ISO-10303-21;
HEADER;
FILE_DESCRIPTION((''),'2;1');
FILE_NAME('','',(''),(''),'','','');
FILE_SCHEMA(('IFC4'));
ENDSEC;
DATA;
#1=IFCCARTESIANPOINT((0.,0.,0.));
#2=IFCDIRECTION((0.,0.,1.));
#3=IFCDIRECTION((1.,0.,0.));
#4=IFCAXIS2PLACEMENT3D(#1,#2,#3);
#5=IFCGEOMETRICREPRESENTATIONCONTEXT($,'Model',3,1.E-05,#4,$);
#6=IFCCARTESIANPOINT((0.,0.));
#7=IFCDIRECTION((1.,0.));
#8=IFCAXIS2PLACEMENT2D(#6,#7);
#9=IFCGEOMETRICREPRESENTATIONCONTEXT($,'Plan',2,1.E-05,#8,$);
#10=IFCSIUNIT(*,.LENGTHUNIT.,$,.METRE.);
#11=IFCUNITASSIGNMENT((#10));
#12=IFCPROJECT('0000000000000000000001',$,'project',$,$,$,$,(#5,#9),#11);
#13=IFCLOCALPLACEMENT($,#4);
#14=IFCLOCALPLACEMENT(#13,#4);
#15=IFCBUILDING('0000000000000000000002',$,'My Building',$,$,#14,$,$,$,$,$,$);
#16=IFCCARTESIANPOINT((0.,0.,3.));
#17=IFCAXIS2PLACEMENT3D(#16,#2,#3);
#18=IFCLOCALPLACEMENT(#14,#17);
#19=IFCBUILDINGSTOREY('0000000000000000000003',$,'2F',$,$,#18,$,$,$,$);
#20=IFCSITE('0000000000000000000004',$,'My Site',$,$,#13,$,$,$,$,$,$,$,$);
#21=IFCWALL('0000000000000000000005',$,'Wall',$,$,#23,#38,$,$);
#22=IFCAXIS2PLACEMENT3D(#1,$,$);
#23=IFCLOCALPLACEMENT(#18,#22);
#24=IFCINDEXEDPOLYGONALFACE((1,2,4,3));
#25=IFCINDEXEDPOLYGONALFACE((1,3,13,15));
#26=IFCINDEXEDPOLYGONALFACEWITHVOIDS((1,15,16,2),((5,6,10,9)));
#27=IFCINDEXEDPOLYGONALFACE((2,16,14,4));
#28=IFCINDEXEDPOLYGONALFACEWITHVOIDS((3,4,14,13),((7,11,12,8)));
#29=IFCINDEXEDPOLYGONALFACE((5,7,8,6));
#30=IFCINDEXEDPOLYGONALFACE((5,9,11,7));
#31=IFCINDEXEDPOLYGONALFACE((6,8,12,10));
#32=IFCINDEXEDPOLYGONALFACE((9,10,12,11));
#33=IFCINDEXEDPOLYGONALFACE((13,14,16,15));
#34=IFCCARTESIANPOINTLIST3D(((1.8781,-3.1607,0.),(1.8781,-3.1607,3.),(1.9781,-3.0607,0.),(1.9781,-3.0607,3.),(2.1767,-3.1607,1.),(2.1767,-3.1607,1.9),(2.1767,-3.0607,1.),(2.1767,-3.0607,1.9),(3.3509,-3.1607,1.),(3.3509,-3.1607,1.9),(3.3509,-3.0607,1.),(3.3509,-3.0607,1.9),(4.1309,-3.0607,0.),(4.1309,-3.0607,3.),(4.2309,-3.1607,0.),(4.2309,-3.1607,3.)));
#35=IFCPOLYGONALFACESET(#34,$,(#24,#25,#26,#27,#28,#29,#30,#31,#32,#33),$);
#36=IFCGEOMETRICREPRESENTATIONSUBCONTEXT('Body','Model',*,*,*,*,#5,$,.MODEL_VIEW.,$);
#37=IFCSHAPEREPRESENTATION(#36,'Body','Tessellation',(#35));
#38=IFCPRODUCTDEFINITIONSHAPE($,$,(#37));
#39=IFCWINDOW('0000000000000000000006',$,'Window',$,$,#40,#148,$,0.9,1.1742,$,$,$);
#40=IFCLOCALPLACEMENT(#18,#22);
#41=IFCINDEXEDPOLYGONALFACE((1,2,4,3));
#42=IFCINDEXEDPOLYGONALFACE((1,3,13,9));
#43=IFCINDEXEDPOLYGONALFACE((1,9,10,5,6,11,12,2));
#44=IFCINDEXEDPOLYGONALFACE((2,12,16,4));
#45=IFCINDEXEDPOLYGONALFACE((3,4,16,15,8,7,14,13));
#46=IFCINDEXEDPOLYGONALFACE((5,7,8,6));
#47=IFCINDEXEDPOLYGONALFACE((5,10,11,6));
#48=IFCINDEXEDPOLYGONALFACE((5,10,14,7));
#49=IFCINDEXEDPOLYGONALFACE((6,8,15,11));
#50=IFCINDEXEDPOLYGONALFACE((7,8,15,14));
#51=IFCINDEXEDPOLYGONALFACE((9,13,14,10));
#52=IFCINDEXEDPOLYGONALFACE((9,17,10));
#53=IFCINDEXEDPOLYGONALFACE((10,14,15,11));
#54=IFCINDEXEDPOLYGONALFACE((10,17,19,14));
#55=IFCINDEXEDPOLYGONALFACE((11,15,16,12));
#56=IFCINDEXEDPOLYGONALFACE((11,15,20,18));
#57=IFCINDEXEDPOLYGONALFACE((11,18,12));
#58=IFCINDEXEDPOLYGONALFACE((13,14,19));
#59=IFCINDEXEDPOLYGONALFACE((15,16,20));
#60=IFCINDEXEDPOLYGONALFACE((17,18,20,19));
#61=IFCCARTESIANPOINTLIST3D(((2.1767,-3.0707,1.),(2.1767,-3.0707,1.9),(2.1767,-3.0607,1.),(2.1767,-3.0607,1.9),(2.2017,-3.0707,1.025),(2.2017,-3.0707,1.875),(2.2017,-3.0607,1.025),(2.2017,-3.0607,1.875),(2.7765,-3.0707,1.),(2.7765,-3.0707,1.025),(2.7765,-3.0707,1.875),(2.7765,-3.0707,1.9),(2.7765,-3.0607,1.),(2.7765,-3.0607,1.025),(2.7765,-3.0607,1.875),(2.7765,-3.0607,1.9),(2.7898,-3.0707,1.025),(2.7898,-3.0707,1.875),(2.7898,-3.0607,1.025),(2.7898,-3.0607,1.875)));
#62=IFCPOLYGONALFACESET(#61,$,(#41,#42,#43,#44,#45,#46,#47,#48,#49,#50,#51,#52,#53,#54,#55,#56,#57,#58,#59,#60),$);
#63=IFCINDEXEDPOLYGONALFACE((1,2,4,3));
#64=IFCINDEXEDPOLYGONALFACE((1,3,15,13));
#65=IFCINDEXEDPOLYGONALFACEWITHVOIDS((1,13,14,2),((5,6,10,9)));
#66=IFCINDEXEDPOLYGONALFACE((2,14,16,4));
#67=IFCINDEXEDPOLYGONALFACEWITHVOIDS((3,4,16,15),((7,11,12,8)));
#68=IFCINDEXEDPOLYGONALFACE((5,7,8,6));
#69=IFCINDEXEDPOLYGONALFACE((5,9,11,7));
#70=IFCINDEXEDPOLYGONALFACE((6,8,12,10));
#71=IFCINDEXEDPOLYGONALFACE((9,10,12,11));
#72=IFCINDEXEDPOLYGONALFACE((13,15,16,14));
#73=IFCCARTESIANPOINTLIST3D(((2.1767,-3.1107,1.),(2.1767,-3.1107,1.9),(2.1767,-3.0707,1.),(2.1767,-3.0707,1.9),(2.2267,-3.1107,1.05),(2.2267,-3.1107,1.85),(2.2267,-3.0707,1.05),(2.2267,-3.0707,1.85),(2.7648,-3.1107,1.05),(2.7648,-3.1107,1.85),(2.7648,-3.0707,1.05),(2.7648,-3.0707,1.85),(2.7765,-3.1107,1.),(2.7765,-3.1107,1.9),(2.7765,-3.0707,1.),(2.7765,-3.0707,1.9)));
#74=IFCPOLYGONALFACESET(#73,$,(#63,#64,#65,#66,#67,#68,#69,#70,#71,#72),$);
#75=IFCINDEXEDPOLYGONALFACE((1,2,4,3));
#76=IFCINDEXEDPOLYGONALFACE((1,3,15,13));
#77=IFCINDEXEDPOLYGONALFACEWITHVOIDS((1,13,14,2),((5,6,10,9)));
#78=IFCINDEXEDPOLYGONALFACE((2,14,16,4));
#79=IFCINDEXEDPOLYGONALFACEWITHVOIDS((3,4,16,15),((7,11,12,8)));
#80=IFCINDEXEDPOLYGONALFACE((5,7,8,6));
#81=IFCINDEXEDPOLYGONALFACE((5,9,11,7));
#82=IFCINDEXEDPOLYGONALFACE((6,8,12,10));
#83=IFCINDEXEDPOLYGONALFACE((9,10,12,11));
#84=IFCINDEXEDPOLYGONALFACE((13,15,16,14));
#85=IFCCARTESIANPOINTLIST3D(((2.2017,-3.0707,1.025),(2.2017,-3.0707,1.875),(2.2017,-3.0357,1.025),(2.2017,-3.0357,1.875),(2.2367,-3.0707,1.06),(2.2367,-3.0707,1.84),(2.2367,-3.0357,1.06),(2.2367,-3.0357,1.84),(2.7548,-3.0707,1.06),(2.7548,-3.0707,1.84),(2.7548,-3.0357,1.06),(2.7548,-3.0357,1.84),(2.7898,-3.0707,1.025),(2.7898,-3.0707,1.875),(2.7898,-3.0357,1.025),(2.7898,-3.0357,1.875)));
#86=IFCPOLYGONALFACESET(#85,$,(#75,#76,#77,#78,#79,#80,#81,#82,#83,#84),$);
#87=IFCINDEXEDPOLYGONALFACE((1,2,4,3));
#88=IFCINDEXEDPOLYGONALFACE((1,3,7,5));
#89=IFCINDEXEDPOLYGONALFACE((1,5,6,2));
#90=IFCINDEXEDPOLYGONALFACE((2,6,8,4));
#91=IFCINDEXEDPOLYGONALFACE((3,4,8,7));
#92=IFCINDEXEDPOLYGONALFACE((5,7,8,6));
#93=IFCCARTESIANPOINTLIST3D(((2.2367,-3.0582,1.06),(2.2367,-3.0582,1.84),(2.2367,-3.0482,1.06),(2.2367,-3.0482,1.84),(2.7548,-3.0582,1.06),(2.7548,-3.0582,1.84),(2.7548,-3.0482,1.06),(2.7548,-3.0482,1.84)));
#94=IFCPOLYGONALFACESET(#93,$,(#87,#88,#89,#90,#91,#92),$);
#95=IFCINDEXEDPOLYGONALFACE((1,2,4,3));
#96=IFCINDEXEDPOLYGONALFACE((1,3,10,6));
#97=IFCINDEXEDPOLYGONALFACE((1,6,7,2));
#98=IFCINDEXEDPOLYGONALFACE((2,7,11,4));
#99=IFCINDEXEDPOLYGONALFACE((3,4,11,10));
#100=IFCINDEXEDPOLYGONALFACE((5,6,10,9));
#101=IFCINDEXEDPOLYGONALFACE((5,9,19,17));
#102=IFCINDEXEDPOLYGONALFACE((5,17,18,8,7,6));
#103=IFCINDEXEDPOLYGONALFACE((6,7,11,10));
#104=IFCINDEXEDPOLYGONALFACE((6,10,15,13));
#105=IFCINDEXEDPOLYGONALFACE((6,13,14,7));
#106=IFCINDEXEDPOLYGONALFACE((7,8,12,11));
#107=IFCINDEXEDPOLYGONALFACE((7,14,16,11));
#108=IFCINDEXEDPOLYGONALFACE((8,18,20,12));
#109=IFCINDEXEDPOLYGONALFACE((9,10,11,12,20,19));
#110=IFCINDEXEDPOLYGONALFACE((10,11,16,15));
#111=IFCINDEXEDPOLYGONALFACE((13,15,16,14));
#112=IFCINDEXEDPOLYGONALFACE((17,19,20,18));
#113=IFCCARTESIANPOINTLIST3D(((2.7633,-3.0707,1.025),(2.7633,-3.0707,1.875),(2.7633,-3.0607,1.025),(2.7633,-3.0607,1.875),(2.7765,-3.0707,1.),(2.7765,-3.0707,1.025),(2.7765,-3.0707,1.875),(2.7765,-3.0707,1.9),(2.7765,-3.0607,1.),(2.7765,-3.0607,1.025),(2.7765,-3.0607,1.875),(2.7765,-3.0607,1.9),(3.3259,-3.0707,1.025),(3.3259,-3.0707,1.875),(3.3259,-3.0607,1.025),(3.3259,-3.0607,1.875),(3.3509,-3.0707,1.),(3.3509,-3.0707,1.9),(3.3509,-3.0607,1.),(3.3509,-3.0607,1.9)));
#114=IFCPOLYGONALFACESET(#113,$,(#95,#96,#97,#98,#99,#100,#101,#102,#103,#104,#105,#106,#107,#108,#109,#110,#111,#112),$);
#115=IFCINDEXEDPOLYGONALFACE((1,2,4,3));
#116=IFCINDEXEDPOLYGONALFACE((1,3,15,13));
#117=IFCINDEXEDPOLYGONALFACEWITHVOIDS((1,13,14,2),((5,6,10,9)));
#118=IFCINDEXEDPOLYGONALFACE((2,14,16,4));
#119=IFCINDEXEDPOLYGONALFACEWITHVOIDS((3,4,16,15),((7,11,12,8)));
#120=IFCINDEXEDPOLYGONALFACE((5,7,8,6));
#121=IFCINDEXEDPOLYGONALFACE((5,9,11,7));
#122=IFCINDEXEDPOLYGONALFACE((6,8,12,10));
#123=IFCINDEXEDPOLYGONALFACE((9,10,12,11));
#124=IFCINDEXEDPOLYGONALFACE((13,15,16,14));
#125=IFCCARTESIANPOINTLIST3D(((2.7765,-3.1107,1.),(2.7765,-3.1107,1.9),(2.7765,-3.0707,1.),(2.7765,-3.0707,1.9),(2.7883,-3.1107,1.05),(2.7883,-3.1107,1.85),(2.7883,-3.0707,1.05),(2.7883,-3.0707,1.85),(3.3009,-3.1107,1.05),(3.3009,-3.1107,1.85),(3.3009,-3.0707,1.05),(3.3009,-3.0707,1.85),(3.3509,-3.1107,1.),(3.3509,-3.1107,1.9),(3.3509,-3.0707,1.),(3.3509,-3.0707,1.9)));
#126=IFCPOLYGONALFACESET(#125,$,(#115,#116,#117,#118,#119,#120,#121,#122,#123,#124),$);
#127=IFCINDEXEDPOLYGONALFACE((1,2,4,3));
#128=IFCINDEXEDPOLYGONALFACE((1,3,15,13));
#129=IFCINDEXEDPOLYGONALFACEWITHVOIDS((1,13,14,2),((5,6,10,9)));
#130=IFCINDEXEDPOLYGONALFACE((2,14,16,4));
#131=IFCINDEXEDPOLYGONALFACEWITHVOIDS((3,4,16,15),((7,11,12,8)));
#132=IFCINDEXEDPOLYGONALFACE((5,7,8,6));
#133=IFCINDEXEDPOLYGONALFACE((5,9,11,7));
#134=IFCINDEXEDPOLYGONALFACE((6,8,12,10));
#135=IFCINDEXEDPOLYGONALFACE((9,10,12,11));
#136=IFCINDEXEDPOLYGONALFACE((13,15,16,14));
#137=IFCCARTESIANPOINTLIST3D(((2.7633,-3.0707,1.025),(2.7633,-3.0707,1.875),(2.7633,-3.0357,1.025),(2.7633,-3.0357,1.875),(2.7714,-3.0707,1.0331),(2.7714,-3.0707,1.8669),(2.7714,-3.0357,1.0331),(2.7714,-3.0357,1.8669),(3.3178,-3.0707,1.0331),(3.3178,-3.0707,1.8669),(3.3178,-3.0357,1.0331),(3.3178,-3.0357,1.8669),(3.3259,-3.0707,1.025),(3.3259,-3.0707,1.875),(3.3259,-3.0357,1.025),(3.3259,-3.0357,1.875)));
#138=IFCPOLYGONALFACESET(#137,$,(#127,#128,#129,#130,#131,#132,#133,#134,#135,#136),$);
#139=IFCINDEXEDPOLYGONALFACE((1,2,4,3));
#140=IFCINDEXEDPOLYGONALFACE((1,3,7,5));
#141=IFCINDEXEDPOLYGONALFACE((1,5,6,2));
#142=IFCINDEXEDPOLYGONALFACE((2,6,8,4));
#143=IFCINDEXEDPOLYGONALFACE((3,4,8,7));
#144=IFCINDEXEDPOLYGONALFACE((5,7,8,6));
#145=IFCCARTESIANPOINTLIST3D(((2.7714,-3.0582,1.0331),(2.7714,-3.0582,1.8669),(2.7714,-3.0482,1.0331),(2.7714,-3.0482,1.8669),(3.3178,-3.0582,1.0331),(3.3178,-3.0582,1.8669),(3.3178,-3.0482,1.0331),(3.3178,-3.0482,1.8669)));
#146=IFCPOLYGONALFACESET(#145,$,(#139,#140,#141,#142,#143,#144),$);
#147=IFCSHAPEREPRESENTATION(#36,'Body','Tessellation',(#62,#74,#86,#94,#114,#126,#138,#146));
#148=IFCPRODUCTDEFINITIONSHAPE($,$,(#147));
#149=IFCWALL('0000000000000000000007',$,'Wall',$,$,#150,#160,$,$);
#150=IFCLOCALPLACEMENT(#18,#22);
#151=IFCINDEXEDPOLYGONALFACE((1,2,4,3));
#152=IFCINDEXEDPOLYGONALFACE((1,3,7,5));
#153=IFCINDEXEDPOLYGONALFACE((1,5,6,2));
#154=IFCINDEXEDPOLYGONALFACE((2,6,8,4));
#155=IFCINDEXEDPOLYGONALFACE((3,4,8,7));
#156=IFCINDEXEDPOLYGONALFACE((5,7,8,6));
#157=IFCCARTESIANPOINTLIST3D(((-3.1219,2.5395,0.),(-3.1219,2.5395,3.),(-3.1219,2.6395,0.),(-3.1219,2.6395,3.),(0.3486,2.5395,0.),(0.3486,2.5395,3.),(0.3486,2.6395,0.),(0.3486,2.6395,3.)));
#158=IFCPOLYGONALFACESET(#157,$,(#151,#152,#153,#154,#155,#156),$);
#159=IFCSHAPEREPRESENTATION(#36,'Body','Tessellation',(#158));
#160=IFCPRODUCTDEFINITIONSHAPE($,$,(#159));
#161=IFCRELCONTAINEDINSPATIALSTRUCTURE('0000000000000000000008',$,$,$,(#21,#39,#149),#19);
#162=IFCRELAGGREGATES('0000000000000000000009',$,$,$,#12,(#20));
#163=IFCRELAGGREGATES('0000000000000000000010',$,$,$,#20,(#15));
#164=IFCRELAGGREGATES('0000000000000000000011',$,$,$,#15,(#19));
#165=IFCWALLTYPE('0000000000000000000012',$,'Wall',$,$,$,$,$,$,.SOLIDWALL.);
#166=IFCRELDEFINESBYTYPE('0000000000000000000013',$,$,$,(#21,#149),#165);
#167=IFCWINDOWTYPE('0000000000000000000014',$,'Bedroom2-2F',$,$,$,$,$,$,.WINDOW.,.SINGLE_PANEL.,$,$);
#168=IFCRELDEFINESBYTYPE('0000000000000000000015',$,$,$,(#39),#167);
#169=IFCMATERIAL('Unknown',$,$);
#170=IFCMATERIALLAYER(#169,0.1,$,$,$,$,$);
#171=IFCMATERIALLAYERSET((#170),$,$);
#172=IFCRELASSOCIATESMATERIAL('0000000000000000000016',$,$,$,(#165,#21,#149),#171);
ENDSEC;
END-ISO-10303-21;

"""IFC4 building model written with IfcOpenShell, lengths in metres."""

from ifc_helpers import new_model, entity, si_unit, frame, origin_with_axes, origin_2d_with_axis, place, context, subcontext, project, spatial, line, indexed_curve, outline, extrude, shape, source, transform, mapped, material, layer, layer_set, layer_usage, type_object, type_shapes, element, fill, save


model = new_model("IFC4")

# Units and contexts
model_context = context("Model", 3, precision=1e-05, world=origin_with_axes())
plan_context = context("Plan", 2, precision=1e-05, world=origin_2d_with_axis())
body_context_1 = subcontext(model_context, "Body", "Model", "MODEL_VIEW")
body_context_2 = subcontext(plan_context, "Body", "Plan", "PLAN_VIEW")
ifc_project = project(units=[si_unit("LENGTHUNIT", "METRE")], contexts=[model_context, plan_context])

# Site, building, storey
site_placement = place(None, origin_with_axes())
site = spatial("IfcSite", under=ifc_project, at=site_placement, Name="My Site")
building_placement = place(site_placement, origin_with_axes())
building = spatial("IfcBuilding", under=site, at=building_placement, Name="My Building")
storey_placement = place(building_placement, frame((0.0, 0.0, 3.0), z_axis=(0.0, 0.0, 1.0), x_axis=(1.0, 0.0, 0.0)))
storey = spatial("IfcBuildingStorey", under=building, at=storey_placement, Name="2F")

# Shared definitions
ifc_material = material(Name="Unknown")

# Shared definitions
ifc_layer_1 = layer(ifc_material, 0.1)
ifc_layer_set_1 = layer_set([ifc_layer_1])
wall_type = type_object("IfcWallType", Name="Wall", PredefinedType="SOLIDWALL", material=ifc_layer_set_1)

# Wall, opening, window
ifc_layer_usage_1 = layer_usage(ifc_layer_set_1, "AXIS2", "POSITIVE", 0.0)
wall_1_placement = place(storey_placement, frame((1.8781, -3.1607, 0.0), z_axis=(0.0, 0.0, 1.0), x_axis=(1.0, 0.0, 0.0)))
wall_1 = element("IfcWall", 1, at=wall_1_placement, inside=storey, type_object=wall_type, material=ifc_layer_usage_1, Name="Wall", context=body_context_1, shape_type="SweptSolid", body=[
    extrude(outline(indexed_curve([(0.0, 0.0), (0.1, 0.1), (2.2528, 0.1), (2.3528, 0.0)], segments=[line(1, 2, 3, 4, 1)])), origin_with_axes(), (0.0, 0.0, 1.0), 3.0),
])
shared_shape_1 = source(origin_with_axes(), body_context_1, "Body", "SweptSolid", [
    extrude(outline(indexed_curve([(0.0, 0.0), (1.1742, 0.0), (1.1742, 0.9), (0.0, 0.9)], segments=[line(1, 2, 3, 4, 1)])), frame((0.0, -0.6, 0.0), z_axis=(0.0, -1.0, 0.0), x_axis=(1.0, 0.0, 0.0)), (0.0, 0.0, -1.0), 1.2),
])
opening_1_placement = place(wall_1_placement, frame((0.2985, 0.0, 1.0), z_axis=(0.0, 0.0, 1.0), x_axis=(1.0, 0.0, 0.0)))
opening_1 = element("IfcOpeningElement", 2, at=opening_1_placement, cuts=wall_1, PredefinedType="OPENING", context=body_context_1, shape_type="MappedRepresentation", body=[
    mapped(shared_shape_1, transform((0.0, 0.0, 0.0), x_axis=(1.0, 0.0, 0.0), y_axis=(0.0, 1.0, 0.0), z_axis=(0.0, 0.0, 1.0), scale=1.0)),
])
window_type_1 = type_object("IfcWindowType", Name="Bedroom2-2F", PartitioningType="SINGLE_PANEL", PredefinedType="WINDOW")
shared_shape_2 = source(origin_with_axes(), body_context_1, "Body", "SweptSolid", [
    extrude(outline(indexed_curve([(0.0, 0.0), (0.5999, 0.0), (0.5999, 0.9), (0.0, 0.9)], segments=[line(1, 2, 3, 4, 1)]), holes=[indexed_curve([(0.025, 0.025), (0.6131, 0.025), (0.6131, 0.875), (0.025, 0.875)], segments=[line(1, 2, 3, 4, 1)])]), frame((0.0, 0.09, 0.0), z_axis=(0.0, -1.0, 0.0), x_axis=(1.0, 0.0, 0.0)), (0.0, 0.0, -1.0), 0.01),
    extrude(outline(indexed_curve([(0.0, 0.0), (0.5999, 0.0), (0.5999, 0.9), (0.0, 0.9)], segments=[line(1, 2, 3, 4, 1)]), holes=[indexed_curve([(0.05, 0.05), (0.5881, 0.05), (0.5881, 0.85), (0.05, 0.85)], segments=[line(1, 2, 3, 4, 1)])]), frame((0.0, 0.05, 0.0), z_axis=(0.0, -1.0, 0.0), x_axis=(1.0, 0.0, 0.0)), (0.0, 0.0, -1.0), 0.04),
    extrude(outline(indexed_curve([(0.0, 0.0), (0.5881, 0.0), (0.5881, 0.85), (0.0, 0.85)], segments=[line(1, 2, 3, 4, 1)]), holes=[indexed_curve([(0.035, 0.035), (0.5531, 0.035), (0.5531, 0.815), (0.035, 0.815)], segments=[line(1, 2, 3, 4, 1)])]), frame((0.025, 0.09, 0.025), z_axis=(0.0, -1.0, 0.0), x_axis=(1.0, 0.0, 0.0)), (0.0, 0.0, -1.0), 0.035),
    extrude(outline(indexed_curve([(0.035, 0.035), (0.5531, 0.035), (0.5531, 0.815), (0.035, 0.815)], segments=[line(1, 2, 3, 4, 1)])), frame((0.025, 0.1025, 0.025), z_axis=(0.0, -1.0, 0.0), x_axis=(1.0, 0.0, 0.0)), (0.0, 0.0, -1.0), 0.01),
    extrude(outline(indexed_curve([(0.0, 0.0), (0.5744, 0.0), (0.5744, 0.9), (0.0, 0.9)], segments=[line(1, 2, 3, 4, 1)]), holes=[indexed_curve([(-0.0132, 0.025), (0.5494, 0.025), (0.5494, 0.875), (-0.0132, 0.875)], segments=[line(1, 2, 3, 4, 1)])]), frame((0.5999, 0.09, 0.0), z_axis=(0.0, -1.0, 0.0), x_axis=(1.0, 0.0, 0.0)), (0.0, 0.0, -1.0), 0.01),
    extrude(outline(indexed_curve([(0.0, 0.0), (0.5744, 0.0), (0.5744, 0.9), (0.0, 0.9)], segments=[line(1, 2, 3, 4, 1)]), holes=[indexed_curve([(0.0118, 0.05), (0.5244, 0.05), (0.5244, 0.85), (0.0118, 0.85)], segments=[line(1, 2, 3, 4, 1)])]), frame((0.5999, 0.05, 0.0), z_axis=(0.0, -1.0, 0.0), x_axis=(1.0, 0.0, 0.0)), (0.0, 0.0, -1.0), 0.04),
    extrude(outline(indexed_curve([(0.0, 0.0), (0.5626, 0.0), (0.5626, 0.85), (0.0, 0.85)], segments=[line(1, 2, 3, 4, 1)]), holes=[indexed_curve([(0.0081, 0.0081), (0.5545, 0.0081), (0.5545, 0.8419), (0.0081, 0.8419)], segments=[line(1, 2, 3, 4, 1)])]), frame((0.5866, 0.09, 0.025), z_axis=(0.0, -1.0, 0.0), x_axis=(1.0, 0.0, 0.0)), (0.0, 0.0, -1.0), 0.035),
    extrude(outline(indexed_curve([(0.0081, 0.0081), (0.5545, 0.0081), (0.5545, 0.8419), (0.0081, 0.8419)], segments=[line(1, 2, 3, 4, 1)])), frame((0.5866, 0.1025, 0.025), z_axis=(0.0, -1.0, 0.0), x_axis=(1.0, 0.0, 0.0)), (0.0, 0.0, -1.0), 0.01),
])
shared_shape_3 = source(origin_with_axes(), body_context_2, "Body", "Curve2D", [
    entity("IfcIndexedPolyCurve", entity("IfcCartesianPointList2D", [[0.05, 0.05], [0.5881, 0.05]])),
    entity("IfcIndexedPolyCurve", entity("IfcCartesianPointList2D", [[0.0, 0.1], [0.025, 0.1], [0.025, 0.09], [0.05, 0.09], [0.05, 0.05], [0.0, 0.05]]), [entity("IfcLineIndex", [1, 2, 3, 4, 5, 6, 1])]),
    entity("IfcIndexedPolyCurve", entity("IfcCartesianPointList2D", [[0.5999, 0.1], [0.6131, 0.1], [0.6131, 0.09], [0.5881, 0.09], [0.5881, 0.05], [0.5999, 0.05]])),
    entity("IfcIndexedPolyCurve", entity("IfcCartesianPointList2D", [[0.025, 0.09], [0.06, 0.09], [0.06, 0.125], [0.025, 0.125]]), [entity("IfcLineIndex", [1, 2, 3, 4, 1])]),
    entity("IfcIndexedPolyCurve", entity("IfcCartesianPointList2D", [[0.6131, 0.09], [0.5781, 0.09], [0.5781, 0.125], [0.6131, 0.125]]), [entity("IfcLineIndex", [1, 2, 3, 4, 1])]),
    entity("IfcIndexedPolyCurve", entity("IfcCartesianPointList2D", [[0.06, 0.09], [0.5781, 0.09]])),
    entity("IfcIndexedPolyCurve", entity("IfcCartesianPointList2D", [[0.06, 0.125], [0.5781, 0.125]])),
    entity("IfcIndexedPolyCurve", entity("IfcCartesianPointList2D", [[0.06, 0.1075], [0.5781, 0.1075]])),
    entity("IfcIndexedPolyCurve", entity("IfcCartesianPointList2D", [[0.6116, 0.05], [1.1242, 0.05]])),
    entity("IfcIndexedPolyCurve", entity("IfcCartesianPointList2D", [[0.5999, 0.1], [0.5866, 0.1], [0.5866, 0.09], [0.6116, 0.09], [0.6116, 0.05], [0.5999, 0.05]])),
    entity("IfcIndexedPolyCurve", entity("IfcCartesianPointList2D", [[1.1742, 0.1], [1.1492, 0.1], [1.1492, 0.09], [1.1242, 0.09], [1.1242, 0.05], [1.1742, 0.05]]), [entity("IfcLineIndex", [1, 2, 3, 4, 5, 6, 1])]),
    entity("IfcIndexedPolyCurve", entity("IfcCartesianPointList2D", [[0.5866, 0.09], [0.5947, 0.09], [0.5947, 0.125], [0.5866, 0.125]]), [entity("IfcLineIndex", [1, 2, 3, 4, 1])]),
    entity("IfcIndexedPolyCurve", entity("IfcCartesianPointList2D", [[1.1492, 0.09], [1.1412, 0.09], [1.1412, 0.125], [1.1492, 0.125]]), [entity("IfcLineIndex", [1, 2, 3, 4, 1])]),
    entity("IfcIndexedPolyCurve", entity("IfcCartesianPointList2D", [[0.5947, 0.09], [1.1412, 0.09]])),
    entity("IfcIndexedPolyCurve", entity("IfcCartesianPointList2D", [[0.5947, 0.125], [1.1412, 0.125]])),
    entity("IfcIndexedPolyCurve", entity("IfcCartesianPointList2D", [[0.5947, 0.1075], [1.1412, 0.1075]])),
])
type_shapes(window_type_1, [shared_shape_2, shared_shape_3])
window_1_placement = place(opening_1_placement, frame((0.0, 0.0, 0.0), z_axis=(0.0, 0.0, 1.0), x_axis=(1.0, 0.0, 0.0)))
window_1 = element("IfcWindow", 3, at=window_1_placement, inside=storey, type_object=window_type_1, Name="Window", OverallHeight=0.9, OverallWidth=1.1742, shapes=[
    shape(body_context_1, "Body", "MappedRepresentation", [mapped(shared_shape_2, transform((0.0, 0.0, 0.0), x_axis=(1.0, 0.0, 0.0), y_axis=(0.0, 1.0, 0.0), z_axis=(0.0, 0.0, 1.0), scale=1.0))]),
    shape(body_context_2, "Body", "MappedRepresentation", [mapped(shared_shape_3, transform((0.0, 0.0, 0.0), x_axis=(1.0, 0.0, 0.0), y_axis=(0.0, 1.0, 0.0), z_axis=(0.0, 0.0, 1.0), scale=1.0))]),
])
fill(opening_1, window_1)

# Wall
ifc_layer_usage_2 = layer_usage(ifc_layer_set_1, "AXIS2", "POSITIVE", 0.0)
wall_2_placement = place(storey_placement, frame((0.3486, 2.6395, 0.0), z_axis=(0.0, 0.0, 1.0), x_axis=(-1.0, 0.0, 0.0)))
element("IfcWall", 4, at=wall_2_placement, inside=storey, type_object=wall_type, material=ifc_layer_usage_2, Name="Wall", context=body_context_1, shape_type="SweptSolid", body=[
    extrude(outline(indexed_curve([(0.0, 0.0), (0.0, 0.1), (3.4705, 0.1), (3.4705, 0.0)], segments=[line(1, 2, 3, 4, 1)])), origin_with_axes(), (0.0, 0.0, 1.0), 3.0),
])

save(model, "model.ifc")
